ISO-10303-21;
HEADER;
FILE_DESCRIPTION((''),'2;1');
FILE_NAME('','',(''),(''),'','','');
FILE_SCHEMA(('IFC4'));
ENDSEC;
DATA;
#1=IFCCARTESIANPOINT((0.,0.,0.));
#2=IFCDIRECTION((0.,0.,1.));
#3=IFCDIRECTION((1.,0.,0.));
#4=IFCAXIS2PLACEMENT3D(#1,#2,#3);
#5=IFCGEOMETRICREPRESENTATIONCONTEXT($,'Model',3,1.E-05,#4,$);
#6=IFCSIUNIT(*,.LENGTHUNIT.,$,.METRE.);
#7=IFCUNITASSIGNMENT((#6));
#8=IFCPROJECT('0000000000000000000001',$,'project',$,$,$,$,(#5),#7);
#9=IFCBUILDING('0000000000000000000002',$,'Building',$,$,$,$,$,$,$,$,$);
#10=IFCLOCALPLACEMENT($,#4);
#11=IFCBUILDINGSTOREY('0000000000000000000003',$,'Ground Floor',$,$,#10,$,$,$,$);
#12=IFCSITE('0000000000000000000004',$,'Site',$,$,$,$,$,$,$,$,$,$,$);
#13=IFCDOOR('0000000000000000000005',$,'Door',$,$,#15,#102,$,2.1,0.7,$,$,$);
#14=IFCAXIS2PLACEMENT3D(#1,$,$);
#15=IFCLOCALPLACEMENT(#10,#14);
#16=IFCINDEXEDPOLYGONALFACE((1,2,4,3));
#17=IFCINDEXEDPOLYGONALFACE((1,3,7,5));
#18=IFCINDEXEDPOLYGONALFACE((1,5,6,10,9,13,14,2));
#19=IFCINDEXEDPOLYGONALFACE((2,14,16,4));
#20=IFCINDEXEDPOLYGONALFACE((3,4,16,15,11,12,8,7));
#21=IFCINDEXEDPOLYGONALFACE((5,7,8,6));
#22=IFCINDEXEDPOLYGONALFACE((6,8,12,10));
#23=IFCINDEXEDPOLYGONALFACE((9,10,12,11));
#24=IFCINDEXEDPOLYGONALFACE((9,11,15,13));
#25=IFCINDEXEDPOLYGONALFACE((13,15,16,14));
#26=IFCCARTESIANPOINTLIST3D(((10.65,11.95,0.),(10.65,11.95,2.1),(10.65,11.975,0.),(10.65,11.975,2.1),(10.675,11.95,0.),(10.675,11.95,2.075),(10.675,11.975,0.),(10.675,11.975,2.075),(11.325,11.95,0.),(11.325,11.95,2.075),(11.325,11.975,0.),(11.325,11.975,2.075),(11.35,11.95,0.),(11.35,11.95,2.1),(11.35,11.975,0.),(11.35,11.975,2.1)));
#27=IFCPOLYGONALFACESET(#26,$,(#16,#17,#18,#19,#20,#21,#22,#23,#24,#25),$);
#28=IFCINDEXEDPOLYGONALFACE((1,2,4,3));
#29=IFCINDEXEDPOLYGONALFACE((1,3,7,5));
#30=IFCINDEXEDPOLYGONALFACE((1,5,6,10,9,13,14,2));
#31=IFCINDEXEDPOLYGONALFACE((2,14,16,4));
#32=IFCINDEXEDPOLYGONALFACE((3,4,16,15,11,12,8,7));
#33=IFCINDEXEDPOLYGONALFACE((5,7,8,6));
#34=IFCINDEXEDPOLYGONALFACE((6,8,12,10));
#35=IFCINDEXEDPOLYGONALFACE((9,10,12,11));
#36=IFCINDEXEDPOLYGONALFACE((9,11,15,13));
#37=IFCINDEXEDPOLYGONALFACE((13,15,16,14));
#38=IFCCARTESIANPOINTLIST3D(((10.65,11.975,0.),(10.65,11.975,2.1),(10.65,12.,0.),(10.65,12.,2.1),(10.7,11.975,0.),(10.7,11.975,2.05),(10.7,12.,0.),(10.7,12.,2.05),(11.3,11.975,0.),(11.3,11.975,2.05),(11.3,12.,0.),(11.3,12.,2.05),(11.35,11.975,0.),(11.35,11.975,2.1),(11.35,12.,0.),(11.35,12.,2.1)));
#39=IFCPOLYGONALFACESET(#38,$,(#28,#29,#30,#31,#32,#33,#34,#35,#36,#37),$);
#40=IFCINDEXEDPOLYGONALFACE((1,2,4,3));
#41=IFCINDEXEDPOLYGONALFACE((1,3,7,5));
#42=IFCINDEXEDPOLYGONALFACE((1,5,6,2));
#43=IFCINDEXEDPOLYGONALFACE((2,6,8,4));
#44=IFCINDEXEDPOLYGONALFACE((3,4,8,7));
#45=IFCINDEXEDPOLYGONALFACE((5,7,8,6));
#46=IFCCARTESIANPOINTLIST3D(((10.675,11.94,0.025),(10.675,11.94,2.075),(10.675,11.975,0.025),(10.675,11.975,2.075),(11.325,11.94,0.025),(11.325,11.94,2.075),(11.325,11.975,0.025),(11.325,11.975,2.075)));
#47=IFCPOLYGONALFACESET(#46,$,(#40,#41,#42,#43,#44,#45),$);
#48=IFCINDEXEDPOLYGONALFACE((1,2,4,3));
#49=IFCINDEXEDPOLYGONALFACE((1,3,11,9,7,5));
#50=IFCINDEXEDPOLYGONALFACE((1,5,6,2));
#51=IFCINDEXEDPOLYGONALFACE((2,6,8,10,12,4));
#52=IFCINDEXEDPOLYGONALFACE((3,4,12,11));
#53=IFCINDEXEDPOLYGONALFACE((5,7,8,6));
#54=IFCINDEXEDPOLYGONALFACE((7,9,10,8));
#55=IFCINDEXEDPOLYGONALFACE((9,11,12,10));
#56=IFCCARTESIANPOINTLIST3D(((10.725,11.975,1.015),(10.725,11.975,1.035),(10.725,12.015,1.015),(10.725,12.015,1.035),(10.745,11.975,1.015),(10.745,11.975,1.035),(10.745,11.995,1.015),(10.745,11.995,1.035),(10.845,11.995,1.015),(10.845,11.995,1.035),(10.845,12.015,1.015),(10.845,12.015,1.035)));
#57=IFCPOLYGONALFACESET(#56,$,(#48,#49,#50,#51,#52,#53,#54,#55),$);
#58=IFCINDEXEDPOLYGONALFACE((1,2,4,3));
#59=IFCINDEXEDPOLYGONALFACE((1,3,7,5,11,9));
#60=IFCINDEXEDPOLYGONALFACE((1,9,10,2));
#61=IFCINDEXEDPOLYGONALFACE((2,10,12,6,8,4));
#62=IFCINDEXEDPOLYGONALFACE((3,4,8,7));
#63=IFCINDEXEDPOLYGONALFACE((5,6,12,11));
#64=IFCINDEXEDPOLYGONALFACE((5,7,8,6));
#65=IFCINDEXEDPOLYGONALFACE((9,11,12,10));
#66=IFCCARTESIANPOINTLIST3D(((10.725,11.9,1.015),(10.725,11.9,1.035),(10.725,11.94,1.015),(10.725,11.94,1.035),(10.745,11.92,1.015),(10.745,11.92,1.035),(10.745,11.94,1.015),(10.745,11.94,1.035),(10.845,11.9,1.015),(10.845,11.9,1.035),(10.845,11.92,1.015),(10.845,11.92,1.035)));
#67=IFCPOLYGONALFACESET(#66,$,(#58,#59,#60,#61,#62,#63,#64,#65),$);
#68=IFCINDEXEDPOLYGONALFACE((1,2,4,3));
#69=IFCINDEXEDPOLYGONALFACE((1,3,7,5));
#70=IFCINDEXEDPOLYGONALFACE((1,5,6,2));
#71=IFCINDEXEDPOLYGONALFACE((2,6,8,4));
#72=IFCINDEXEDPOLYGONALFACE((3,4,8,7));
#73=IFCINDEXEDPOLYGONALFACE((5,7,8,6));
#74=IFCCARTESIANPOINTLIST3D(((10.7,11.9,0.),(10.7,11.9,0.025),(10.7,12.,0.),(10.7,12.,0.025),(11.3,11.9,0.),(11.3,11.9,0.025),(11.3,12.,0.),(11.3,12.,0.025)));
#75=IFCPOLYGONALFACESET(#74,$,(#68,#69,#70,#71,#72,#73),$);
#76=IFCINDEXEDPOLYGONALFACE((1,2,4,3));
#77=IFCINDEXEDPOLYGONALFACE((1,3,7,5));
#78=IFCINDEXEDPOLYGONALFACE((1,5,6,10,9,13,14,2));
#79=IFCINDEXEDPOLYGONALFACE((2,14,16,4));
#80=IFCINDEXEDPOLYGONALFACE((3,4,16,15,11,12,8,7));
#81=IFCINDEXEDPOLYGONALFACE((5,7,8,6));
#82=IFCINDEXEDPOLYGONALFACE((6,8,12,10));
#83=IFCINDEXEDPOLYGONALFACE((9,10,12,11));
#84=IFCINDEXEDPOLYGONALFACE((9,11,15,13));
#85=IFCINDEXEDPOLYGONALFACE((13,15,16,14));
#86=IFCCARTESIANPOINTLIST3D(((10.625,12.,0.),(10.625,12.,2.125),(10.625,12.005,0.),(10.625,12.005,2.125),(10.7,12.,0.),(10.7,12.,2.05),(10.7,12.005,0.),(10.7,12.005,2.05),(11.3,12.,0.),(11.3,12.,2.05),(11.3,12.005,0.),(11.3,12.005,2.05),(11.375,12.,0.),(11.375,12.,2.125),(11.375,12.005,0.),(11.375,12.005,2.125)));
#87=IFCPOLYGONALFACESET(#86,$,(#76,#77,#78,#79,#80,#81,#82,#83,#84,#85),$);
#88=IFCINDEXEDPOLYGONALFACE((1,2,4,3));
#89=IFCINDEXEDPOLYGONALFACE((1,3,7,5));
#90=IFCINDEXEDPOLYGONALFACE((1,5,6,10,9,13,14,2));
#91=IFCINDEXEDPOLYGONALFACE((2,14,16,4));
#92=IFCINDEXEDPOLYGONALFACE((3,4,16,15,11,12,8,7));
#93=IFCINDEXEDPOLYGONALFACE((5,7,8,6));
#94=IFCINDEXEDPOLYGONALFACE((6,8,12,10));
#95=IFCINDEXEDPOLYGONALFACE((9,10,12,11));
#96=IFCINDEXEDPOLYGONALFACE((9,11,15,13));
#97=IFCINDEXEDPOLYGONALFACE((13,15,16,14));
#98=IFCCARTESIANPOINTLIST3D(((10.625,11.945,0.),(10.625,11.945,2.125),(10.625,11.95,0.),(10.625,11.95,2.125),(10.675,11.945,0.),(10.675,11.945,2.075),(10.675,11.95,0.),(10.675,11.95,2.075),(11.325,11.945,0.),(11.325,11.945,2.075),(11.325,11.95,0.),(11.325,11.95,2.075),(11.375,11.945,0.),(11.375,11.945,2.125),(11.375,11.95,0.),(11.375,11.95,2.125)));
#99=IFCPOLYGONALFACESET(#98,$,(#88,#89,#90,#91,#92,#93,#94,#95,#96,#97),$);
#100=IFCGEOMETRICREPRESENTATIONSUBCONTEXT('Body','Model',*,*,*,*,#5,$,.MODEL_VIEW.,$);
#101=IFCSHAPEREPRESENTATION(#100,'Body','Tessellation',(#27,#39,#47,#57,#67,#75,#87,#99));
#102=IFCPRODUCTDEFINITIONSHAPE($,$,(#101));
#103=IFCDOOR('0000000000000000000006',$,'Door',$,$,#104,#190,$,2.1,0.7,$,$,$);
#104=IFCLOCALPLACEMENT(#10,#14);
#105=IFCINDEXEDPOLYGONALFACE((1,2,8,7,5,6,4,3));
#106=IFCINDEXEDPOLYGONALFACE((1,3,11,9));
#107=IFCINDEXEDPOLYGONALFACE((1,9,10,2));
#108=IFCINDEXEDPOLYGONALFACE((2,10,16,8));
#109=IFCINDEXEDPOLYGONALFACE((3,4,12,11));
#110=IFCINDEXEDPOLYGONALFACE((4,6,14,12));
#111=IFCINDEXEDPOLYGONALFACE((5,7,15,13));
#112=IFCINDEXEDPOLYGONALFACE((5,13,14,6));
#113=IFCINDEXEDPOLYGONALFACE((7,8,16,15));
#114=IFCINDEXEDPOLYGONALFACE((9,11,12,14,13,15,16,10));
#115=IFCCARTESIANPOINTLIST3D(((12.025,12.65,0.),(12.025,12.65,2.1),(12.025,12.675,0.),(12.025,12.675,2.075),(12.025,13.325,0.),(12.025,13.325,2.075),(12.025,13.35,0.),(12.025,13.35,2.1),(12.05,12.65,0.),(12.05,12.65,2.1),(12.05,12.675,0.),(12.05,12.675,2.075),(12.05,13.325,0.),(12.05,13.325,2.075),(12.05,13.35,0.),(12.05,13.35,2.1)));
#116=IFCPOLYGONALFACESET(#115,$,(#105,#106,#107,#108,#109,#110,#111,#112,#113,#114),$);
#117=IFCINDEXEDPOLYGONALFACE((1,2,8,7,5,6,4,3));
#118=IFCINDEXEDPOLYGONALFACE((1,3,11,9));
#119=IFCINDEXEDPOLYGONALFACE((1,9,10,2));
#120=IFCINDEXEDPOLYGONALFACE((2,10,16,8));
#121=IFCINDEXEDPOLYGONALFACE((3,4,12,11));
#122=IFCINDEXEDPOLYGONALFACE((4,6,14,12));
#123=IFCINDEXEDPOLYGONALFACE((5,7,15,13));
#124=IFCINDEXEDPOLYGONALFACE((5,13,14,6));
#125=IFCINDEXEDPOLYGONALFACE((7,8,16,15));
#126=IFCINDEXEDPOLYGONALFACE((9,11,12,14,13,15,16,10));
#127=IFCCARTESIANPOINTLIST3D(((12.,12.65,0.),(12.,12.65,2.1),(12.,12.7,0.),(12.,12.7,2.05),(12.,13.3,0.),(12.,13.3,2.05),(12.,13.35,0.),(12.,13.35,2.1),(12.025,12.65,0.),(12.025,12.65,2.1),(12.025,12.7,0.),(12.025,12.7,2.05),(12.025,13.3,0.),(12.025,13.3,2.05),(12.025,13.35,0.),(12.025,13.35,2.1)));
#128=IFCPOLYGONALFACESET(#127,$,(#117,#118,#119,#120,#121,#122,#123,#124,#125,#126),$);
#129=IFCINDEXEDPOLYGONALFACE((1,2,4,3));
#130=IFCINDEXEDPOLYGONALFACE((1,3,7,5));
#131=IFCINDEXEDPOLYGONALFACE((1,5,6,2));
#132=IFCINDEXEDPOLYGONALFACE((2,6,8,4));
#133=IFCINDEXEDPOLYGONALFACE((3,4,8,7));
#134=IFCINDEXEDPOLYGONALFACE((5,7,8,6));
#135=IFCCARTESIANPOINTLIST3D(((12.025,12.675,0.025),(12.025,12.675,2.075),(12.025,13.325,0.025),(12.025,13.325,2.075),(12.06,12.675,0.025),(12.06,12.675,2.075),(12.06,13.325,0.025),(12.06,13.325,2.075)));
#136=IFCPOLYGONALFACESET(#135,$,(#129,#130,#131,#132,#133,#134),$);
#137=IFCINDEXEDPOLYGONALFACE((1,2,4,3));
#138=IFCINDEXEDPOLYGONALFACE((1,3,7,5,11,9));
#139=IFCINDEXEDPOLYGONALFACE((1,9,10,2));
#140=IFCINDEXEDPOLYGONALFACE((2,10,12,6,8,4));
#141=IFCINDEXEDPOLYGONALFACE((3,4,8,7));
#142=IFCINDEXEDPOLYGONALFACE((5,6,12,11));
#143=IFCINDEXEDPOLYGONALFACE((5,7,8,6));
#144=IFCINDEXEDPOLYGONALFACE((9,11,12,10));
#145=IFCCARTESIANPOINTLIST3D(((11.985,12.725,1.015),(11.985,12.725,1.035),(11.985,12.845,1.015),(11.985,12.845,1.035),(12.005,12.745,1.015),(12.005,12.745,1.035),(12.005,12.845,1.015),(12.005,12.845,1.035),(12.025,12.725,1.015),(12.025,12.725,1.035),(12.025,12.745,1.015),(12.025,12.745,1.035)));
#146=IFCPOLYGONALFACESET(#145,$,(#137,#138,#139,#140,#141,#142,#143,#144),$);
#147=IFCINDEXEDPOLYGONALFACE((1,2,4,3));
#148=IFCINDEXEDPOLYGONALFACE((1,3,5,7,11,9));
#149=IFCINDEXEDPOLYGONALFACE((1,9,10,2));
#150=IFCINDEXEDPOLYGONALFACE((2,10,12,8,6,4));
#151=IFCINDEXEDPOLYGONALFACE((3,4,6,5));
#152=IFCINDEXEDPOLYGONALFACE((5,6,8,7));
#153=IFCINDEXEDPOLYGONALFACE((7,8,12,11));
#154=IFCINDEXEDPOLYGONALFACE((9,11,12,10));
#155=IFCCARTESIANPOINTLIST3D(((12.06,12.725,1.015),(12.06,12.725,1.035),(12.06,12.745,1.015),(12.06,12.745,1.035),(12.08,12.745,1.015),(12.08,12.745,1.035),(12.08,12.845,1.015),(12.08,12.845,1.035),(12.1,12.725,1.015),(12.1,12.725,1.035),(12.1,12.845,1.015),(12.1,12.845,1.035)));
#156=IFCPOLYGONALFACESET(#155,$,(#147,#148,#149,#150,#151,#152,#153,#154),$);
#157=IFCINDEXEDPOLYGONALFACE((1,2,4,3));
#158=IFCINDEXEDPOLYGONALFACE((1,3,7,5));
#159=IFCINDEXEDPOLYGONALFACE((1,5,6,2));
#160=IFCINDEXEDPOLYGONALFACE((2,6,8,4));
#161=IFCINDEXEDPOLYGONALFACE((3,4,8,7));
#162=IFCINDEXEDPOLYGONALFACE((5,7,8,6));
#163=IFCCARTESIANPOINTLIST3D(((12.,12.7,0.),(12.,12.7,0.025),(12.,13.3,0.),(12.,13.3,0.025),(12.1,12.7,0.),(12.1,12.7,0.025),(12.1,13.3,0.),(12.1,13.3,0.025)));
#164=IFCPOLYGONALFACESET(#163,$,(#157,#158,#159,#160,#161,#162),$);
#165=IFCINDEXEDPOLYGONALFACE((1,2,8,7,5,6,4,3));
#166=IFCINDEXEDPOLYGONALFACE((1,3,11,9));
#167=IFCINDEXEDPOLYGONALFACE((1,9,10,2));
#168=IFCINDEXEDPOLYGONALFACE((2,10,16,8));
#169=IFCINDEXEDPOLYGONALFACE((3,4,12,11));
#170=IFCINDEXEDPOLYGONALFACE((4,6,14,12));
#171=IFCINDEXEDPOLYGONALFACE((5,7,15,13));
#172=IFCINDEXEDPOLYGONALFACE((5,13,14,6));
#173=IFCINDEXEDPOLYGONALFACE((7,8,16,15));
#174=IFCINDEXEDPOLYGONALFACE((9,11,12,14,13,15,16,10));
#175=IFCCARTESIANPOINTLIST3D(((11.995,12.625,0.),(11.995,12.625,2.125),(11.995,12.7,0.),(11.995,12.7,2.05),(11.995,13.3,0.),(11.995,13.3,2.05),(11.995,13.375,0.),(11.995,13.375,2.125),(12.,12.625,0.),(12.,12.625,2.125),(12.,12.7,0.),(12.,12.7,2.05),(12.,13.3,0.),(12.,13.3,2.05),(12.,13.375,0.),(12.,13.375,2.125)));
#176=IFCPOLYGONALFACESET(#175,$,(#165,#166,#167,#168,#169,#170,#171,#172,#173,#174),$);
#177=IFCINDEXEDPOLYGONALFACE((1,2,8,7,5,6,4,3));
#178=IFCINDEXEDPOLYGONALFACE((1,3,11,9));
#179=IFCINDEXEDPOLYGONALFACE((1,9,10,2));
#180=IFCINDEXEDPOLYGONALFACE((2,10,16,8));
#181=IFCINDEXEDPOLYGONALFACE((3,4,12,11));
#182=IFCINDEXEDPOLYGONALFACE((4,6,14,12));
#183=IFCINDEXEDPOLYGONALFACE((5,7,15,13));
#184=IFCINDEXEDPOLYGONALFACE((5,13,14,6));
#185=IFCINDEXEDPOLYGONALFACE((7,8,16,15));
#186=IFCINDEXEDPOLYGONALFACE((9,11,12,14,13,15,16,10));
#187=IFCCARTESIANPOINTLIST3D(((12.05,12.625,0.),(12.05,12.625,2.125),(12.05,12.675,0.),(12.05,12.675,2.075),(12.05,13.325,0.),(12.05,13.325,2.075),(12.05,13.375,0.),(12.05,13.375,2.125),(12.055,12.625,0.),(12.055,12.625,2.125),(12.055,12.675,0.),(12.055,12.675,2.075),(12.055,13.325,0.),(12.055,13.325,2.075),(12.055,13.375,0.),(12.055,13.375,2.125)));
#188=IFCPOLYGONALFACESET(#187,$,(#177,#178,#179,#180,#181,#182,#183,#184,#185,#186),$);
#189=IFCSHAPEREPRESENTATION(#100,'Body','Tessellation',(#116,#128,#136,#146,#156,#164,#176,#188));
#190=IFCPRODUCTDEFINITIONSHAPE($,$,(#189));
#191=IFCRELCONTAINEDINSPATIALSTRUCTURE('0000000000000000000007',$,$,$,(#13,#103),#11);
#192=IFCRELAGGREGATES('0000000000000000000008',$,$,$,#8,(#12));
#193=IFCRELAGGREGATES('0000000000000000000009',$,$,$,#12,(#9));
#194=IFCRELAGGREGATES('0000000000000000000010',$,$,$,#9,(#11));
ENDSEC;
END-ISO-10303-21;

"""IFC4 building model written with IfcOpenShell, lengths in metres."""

from ifc_helpers import new_model, si_unit, frame, origin_with_axes, place, context, subcontext, project, spatial, line, indexed_curve, outline, extrude, element, save


model = new_model("IFC4")

# Units and contexts
model_context = context("Model", 3, precision=1e-05, world=origin_with_axes())
body_context = subcontext(model_context, "Body", "Model", "MODEL_VIEW")
ifc_project = project(units=[si_unit("LENGTHUNIT", "METRE")], contexts=[model_context])

# Site, building, storey
site = spatial("IfcSite", under=ifc_project, Name="Site")
building = spatial("IfcBuilding", under=site, Name="Building")
storey_placement = place(None, origin_with_axes())
storey = spatial("IfcBuildingStorey", under=building, at=storey_placement, Name="Ground Floor")

# Doors
door_1_placement = place(storey_placement, frame((11.35, 12.0, 0.0), z_axis=(0.0, 0.0, 1.0), x_axis=(-1.0, 0.0, 0.0)))
element("IfcDoor", 1, at=door_1_placement, inside=storey, Name="Door", OverallHeight=2.1, OverallWidth=0.7, context=body_context, shape_type="SweptSolid", body=[
    extrude(outline(indexed_curve([(0.0, 0.0), (0.0, 2.1), (0.7, 2.1), (0.7, 0.0), (0.675, 0.0), (0.675, 2.075), (0.025, 2.075), (0.025, 0.0)], segments=[line(1, 2, 3, 4, 5, 6, 7, 8, 1)])), frame((0.0, 0.025, 0.0), z_axis=(0.0, -1.0, 0.0), x_axis=(1.0, 0.0, 0.0)), (0.0, 0.0, -1.0), 0.025),
    extrude(outline(indexed_curve([(0.0, 0.0), (0.0, 2.1), (0.7, 2.1), (0.7, 0.0), (0.65, 0.0), (0.65, 2.05), (0.05, 2.05), (0.05, 0.0)], segments=[line(1, 2, 3, 4, 5, 6, 7, 8, 1)])), frame((0.0, 0.0, 0.0), z_axis=(0.0, -1.0, 0.0), x_axis=(1.0, 0.0, 0.0)), (0.0, 0.0, -1.0), 0.025),
    extrude(outline(indexed_curve([(0.0, 0.0), (0.65, 0.0), (0.65, 0.035), (0.0, 0.035)], segments=[line(1, 2, 3, 4, 1)])), frame((0.025, 0.025, 0.025), z_axis=(0.0, 0.0, 1.0), x_axis=(1.0, 0.0, 0.0)), (0.0, 0.0, 1.0), 2.05),
    extrude(outline(indexed_curve([(0.0, 0.0), (0.0, -0.04), (-0.12, -0.04), (-0.12, -0.02), (-0.02, -0.02), (-0.02, 0.0)], segments=[line(1, 2, 3, 4, 5, 6, 1)])), frame((0.625, 0.025, 1.015), z_axis=(0.0, 0.0, 1.0), x_axis=(1.0, 0.0, 0.0)), (0.0, 0.0, 1.0), 0.02),
    extrude(outline(indexed_curve([(0.0, 0.0), (0.0, 0.04), (-0.12, 0.04), (-0.12, 0.02), (-0.02, 0.02), (-0.02, 0.0)], segments=[line(1, 2, 3, 4, 5, 6, 1)])), frame((0.625, 0.06, 1.015), z_axis=(0.0, 0.0, 1.0), x_axis=(1.0, 0.0, 0.0)), (0.0, 0.0, 1.0), 0.02),
    extrude(outline(indexed_curve([(0.0, 0.0), (0.6, 0.0), (0.6, 0.1), (0.0, 0.1)], segments=[line(1, 2, 3, 4, 1)])), frame((0.05, 0.0, 0.0), z_axis=(0.0, 0.0, 1.0), x_axis=(1.0, 0.0, 0.0)), (0.0, 0.0, 1.0), 0.025),
    extrude(outline(indexed_curve([(0.0, 0.0), (0.0, 2.125), (0.75, 2.125), (0.75, 0.0), (0.675, 0.0), (0.675, 2.05), (0.075, 2.05), (0.075, 0.0)], segments=[line(1, 2, 3, 4, 5, 6, 7, 8, 1)])), frame((-0.025, -0.005, 0.0), z_axis=(0.0, -1.0, 0.0), x_axis=(1.0, 0.0, 0.0)), (0.0, 0.0, -1.0), 0.005),
    extrude(outline(indexed_curve([(0.0, 0.0), (0.0, 2.125), (0.75, 2.125), (0.75, 0.0), (0.7, 0.0), (0.7, 2.075), (0.05, 2.075), (0.05, 0.0)], segments=[line(1, 2, 3, 4, 5, 6, 7, 8, 1)])), frame((-0.025, 0.05, 0.0), z_axis=(0.0, -1.0, 0.0), x_axis=(1.0, 0.0, 0.0)), (0.0, 0.0, -1.0), 0.005),
])
door_2_placement = place(storey_placement, frame((12.0, 13.35, 0.0), z_axis=(0.0, 0.0, 1.0), x_axis=(0.0, -1.0, 0.0)))
element("IfcDoor", 2, at=door_2_placement, inside=storey, Name="Door", OverallHeight=2.1, OverallWidth=0.7, context=body_context, shape_type="SweptSolid", body=[
    extrude(outline(indexed_curve([(0.0, 0.0), (0.0, 2.1), (0.7, 2.1), (0.7, 0.0), (0.675, 0.0), (0.675, 2.075), (0.025, 2.075), (0.025, 0.0)], segments=[line(1, 2, 3, 4, 5, 6, 7, 8, 1)])), frame((0.0, 0.025, 0.0), z_axis=(0.0, -1.0, 0.0), x_axis=(1.0, 0.0, 0.0)), (0.0, 0.0, -1.0), 0.025),
    extrude(outline(indexed_curve([(0.0, 0.0), (0.0, 2.1), (0.7, 2.1), (0.7, 0.0), (0.65, 0.0), (0.65, 2.05), (0.05, 2.05), (0.05, 0.0)], segments=[line(1, 2, 3, 4, 5, 6, 7, 8, 1)])), frame((0.0, 0.0, 0.0), z_axis=(0.0, -1.0, 0.0), x_axis=(1.0, 0.0, 0.0)), (0.0, 0.0, -1.0), 0.025),
    extrude(outline(indexed_curve([(0.0, 0.0), (0.65, 0.0), (0.65, 0.035), (0.0, 0.035)], segments=[line(1, 2, 3, 4, 1)])), frame((0.025, 0.025, 0.025), z_axis=(0.0, 0.0, 1.0), x_axis=(1.0, 0.0, 0.0)), (0.0, 0.0, 1.0), 2.05),
    extrude(outline(indexed_curve([(0.0, 0.0), (0.0, -0.04), (-0.12, -0.04), (-0.12, -0.02), (-0.02, -0.02), (-0.02, 0.0)], segments=[line(1, 2, 3, 4, 5, 6, 1)])), frame((0.625, 0.025, 1.015), z_axis=(0.0, 0.0, 1.0), x_axis=(1.0, 0.0, 0.0)), (0.0, 0.0, 1.0), 0.02),
    extrude(outline(indexed_curve([(0.0, 0.0), (0.0, 0.04), (-0.12, 0.04), (-0.12, 0.02), (-0.02, 0.02), (-0.02, 0.0)], segments=[line(1, 2, 3, 4, 5, 6, 1)])), frame((0.625, 0.06, 1.015), z_axis=(0.0, 0.0, 1.0), x_axis=(1.0, 0.0, 0.0)), (0.0, 0.0, 1.0), 0.02),
    extrude(outline(indexed_curve([(0.0, 0.0), (0.6, 0.0), (0.6, 0.1), (0.0, 0.1)], segments=[line(1, 2, 3, 4, 1)])), frame((0.05, 0.0, 0.0), z_axis=(0.0, 0.0, 1.0), x_axis=(1.0, 0.0, 0.0)), (0.0, 0.0, 1.0), 0.025),
    extrude(outline(indexed_curve([(0.0, 0.0), (0.0, 2.125), (0.75, 2.125), (0.75, 0.0), (0.675, 0.0), (0.675, 2.05), (0.075, 2.05), (0.075, 0.0)], segments=[line(1, 2, 3, 4, 5, 6, 7, 8, 1)])), frame((-0.025, -0.005, 0.0), z_axis=(0.0, -1.0, 0.0), x_axis=(1.0, 0.0, 0.0)), (0.0, 0.0, -1.0), 0.005),
    extrude(outline(indexed_curve([(0.0, 0.0), (0.0, 2.125), (0.75, 2.125), (0.75, 0.0), (0.7, 0.0), (0.7, 2.075), (0.05, 2.075), (0.05, 0.0)], segments=[line(1, 2, 3, 4, 5, 6, 7, 8, 1)])), frame((-0.025, 0.05, 0.0), z_axis=(0.0, -1.0, 0.0), x_axis=(1.0, 0.0, 0.0)), (0.0, 0.0, -1.0), 0.005),
])

save(model, "model.ifc")
